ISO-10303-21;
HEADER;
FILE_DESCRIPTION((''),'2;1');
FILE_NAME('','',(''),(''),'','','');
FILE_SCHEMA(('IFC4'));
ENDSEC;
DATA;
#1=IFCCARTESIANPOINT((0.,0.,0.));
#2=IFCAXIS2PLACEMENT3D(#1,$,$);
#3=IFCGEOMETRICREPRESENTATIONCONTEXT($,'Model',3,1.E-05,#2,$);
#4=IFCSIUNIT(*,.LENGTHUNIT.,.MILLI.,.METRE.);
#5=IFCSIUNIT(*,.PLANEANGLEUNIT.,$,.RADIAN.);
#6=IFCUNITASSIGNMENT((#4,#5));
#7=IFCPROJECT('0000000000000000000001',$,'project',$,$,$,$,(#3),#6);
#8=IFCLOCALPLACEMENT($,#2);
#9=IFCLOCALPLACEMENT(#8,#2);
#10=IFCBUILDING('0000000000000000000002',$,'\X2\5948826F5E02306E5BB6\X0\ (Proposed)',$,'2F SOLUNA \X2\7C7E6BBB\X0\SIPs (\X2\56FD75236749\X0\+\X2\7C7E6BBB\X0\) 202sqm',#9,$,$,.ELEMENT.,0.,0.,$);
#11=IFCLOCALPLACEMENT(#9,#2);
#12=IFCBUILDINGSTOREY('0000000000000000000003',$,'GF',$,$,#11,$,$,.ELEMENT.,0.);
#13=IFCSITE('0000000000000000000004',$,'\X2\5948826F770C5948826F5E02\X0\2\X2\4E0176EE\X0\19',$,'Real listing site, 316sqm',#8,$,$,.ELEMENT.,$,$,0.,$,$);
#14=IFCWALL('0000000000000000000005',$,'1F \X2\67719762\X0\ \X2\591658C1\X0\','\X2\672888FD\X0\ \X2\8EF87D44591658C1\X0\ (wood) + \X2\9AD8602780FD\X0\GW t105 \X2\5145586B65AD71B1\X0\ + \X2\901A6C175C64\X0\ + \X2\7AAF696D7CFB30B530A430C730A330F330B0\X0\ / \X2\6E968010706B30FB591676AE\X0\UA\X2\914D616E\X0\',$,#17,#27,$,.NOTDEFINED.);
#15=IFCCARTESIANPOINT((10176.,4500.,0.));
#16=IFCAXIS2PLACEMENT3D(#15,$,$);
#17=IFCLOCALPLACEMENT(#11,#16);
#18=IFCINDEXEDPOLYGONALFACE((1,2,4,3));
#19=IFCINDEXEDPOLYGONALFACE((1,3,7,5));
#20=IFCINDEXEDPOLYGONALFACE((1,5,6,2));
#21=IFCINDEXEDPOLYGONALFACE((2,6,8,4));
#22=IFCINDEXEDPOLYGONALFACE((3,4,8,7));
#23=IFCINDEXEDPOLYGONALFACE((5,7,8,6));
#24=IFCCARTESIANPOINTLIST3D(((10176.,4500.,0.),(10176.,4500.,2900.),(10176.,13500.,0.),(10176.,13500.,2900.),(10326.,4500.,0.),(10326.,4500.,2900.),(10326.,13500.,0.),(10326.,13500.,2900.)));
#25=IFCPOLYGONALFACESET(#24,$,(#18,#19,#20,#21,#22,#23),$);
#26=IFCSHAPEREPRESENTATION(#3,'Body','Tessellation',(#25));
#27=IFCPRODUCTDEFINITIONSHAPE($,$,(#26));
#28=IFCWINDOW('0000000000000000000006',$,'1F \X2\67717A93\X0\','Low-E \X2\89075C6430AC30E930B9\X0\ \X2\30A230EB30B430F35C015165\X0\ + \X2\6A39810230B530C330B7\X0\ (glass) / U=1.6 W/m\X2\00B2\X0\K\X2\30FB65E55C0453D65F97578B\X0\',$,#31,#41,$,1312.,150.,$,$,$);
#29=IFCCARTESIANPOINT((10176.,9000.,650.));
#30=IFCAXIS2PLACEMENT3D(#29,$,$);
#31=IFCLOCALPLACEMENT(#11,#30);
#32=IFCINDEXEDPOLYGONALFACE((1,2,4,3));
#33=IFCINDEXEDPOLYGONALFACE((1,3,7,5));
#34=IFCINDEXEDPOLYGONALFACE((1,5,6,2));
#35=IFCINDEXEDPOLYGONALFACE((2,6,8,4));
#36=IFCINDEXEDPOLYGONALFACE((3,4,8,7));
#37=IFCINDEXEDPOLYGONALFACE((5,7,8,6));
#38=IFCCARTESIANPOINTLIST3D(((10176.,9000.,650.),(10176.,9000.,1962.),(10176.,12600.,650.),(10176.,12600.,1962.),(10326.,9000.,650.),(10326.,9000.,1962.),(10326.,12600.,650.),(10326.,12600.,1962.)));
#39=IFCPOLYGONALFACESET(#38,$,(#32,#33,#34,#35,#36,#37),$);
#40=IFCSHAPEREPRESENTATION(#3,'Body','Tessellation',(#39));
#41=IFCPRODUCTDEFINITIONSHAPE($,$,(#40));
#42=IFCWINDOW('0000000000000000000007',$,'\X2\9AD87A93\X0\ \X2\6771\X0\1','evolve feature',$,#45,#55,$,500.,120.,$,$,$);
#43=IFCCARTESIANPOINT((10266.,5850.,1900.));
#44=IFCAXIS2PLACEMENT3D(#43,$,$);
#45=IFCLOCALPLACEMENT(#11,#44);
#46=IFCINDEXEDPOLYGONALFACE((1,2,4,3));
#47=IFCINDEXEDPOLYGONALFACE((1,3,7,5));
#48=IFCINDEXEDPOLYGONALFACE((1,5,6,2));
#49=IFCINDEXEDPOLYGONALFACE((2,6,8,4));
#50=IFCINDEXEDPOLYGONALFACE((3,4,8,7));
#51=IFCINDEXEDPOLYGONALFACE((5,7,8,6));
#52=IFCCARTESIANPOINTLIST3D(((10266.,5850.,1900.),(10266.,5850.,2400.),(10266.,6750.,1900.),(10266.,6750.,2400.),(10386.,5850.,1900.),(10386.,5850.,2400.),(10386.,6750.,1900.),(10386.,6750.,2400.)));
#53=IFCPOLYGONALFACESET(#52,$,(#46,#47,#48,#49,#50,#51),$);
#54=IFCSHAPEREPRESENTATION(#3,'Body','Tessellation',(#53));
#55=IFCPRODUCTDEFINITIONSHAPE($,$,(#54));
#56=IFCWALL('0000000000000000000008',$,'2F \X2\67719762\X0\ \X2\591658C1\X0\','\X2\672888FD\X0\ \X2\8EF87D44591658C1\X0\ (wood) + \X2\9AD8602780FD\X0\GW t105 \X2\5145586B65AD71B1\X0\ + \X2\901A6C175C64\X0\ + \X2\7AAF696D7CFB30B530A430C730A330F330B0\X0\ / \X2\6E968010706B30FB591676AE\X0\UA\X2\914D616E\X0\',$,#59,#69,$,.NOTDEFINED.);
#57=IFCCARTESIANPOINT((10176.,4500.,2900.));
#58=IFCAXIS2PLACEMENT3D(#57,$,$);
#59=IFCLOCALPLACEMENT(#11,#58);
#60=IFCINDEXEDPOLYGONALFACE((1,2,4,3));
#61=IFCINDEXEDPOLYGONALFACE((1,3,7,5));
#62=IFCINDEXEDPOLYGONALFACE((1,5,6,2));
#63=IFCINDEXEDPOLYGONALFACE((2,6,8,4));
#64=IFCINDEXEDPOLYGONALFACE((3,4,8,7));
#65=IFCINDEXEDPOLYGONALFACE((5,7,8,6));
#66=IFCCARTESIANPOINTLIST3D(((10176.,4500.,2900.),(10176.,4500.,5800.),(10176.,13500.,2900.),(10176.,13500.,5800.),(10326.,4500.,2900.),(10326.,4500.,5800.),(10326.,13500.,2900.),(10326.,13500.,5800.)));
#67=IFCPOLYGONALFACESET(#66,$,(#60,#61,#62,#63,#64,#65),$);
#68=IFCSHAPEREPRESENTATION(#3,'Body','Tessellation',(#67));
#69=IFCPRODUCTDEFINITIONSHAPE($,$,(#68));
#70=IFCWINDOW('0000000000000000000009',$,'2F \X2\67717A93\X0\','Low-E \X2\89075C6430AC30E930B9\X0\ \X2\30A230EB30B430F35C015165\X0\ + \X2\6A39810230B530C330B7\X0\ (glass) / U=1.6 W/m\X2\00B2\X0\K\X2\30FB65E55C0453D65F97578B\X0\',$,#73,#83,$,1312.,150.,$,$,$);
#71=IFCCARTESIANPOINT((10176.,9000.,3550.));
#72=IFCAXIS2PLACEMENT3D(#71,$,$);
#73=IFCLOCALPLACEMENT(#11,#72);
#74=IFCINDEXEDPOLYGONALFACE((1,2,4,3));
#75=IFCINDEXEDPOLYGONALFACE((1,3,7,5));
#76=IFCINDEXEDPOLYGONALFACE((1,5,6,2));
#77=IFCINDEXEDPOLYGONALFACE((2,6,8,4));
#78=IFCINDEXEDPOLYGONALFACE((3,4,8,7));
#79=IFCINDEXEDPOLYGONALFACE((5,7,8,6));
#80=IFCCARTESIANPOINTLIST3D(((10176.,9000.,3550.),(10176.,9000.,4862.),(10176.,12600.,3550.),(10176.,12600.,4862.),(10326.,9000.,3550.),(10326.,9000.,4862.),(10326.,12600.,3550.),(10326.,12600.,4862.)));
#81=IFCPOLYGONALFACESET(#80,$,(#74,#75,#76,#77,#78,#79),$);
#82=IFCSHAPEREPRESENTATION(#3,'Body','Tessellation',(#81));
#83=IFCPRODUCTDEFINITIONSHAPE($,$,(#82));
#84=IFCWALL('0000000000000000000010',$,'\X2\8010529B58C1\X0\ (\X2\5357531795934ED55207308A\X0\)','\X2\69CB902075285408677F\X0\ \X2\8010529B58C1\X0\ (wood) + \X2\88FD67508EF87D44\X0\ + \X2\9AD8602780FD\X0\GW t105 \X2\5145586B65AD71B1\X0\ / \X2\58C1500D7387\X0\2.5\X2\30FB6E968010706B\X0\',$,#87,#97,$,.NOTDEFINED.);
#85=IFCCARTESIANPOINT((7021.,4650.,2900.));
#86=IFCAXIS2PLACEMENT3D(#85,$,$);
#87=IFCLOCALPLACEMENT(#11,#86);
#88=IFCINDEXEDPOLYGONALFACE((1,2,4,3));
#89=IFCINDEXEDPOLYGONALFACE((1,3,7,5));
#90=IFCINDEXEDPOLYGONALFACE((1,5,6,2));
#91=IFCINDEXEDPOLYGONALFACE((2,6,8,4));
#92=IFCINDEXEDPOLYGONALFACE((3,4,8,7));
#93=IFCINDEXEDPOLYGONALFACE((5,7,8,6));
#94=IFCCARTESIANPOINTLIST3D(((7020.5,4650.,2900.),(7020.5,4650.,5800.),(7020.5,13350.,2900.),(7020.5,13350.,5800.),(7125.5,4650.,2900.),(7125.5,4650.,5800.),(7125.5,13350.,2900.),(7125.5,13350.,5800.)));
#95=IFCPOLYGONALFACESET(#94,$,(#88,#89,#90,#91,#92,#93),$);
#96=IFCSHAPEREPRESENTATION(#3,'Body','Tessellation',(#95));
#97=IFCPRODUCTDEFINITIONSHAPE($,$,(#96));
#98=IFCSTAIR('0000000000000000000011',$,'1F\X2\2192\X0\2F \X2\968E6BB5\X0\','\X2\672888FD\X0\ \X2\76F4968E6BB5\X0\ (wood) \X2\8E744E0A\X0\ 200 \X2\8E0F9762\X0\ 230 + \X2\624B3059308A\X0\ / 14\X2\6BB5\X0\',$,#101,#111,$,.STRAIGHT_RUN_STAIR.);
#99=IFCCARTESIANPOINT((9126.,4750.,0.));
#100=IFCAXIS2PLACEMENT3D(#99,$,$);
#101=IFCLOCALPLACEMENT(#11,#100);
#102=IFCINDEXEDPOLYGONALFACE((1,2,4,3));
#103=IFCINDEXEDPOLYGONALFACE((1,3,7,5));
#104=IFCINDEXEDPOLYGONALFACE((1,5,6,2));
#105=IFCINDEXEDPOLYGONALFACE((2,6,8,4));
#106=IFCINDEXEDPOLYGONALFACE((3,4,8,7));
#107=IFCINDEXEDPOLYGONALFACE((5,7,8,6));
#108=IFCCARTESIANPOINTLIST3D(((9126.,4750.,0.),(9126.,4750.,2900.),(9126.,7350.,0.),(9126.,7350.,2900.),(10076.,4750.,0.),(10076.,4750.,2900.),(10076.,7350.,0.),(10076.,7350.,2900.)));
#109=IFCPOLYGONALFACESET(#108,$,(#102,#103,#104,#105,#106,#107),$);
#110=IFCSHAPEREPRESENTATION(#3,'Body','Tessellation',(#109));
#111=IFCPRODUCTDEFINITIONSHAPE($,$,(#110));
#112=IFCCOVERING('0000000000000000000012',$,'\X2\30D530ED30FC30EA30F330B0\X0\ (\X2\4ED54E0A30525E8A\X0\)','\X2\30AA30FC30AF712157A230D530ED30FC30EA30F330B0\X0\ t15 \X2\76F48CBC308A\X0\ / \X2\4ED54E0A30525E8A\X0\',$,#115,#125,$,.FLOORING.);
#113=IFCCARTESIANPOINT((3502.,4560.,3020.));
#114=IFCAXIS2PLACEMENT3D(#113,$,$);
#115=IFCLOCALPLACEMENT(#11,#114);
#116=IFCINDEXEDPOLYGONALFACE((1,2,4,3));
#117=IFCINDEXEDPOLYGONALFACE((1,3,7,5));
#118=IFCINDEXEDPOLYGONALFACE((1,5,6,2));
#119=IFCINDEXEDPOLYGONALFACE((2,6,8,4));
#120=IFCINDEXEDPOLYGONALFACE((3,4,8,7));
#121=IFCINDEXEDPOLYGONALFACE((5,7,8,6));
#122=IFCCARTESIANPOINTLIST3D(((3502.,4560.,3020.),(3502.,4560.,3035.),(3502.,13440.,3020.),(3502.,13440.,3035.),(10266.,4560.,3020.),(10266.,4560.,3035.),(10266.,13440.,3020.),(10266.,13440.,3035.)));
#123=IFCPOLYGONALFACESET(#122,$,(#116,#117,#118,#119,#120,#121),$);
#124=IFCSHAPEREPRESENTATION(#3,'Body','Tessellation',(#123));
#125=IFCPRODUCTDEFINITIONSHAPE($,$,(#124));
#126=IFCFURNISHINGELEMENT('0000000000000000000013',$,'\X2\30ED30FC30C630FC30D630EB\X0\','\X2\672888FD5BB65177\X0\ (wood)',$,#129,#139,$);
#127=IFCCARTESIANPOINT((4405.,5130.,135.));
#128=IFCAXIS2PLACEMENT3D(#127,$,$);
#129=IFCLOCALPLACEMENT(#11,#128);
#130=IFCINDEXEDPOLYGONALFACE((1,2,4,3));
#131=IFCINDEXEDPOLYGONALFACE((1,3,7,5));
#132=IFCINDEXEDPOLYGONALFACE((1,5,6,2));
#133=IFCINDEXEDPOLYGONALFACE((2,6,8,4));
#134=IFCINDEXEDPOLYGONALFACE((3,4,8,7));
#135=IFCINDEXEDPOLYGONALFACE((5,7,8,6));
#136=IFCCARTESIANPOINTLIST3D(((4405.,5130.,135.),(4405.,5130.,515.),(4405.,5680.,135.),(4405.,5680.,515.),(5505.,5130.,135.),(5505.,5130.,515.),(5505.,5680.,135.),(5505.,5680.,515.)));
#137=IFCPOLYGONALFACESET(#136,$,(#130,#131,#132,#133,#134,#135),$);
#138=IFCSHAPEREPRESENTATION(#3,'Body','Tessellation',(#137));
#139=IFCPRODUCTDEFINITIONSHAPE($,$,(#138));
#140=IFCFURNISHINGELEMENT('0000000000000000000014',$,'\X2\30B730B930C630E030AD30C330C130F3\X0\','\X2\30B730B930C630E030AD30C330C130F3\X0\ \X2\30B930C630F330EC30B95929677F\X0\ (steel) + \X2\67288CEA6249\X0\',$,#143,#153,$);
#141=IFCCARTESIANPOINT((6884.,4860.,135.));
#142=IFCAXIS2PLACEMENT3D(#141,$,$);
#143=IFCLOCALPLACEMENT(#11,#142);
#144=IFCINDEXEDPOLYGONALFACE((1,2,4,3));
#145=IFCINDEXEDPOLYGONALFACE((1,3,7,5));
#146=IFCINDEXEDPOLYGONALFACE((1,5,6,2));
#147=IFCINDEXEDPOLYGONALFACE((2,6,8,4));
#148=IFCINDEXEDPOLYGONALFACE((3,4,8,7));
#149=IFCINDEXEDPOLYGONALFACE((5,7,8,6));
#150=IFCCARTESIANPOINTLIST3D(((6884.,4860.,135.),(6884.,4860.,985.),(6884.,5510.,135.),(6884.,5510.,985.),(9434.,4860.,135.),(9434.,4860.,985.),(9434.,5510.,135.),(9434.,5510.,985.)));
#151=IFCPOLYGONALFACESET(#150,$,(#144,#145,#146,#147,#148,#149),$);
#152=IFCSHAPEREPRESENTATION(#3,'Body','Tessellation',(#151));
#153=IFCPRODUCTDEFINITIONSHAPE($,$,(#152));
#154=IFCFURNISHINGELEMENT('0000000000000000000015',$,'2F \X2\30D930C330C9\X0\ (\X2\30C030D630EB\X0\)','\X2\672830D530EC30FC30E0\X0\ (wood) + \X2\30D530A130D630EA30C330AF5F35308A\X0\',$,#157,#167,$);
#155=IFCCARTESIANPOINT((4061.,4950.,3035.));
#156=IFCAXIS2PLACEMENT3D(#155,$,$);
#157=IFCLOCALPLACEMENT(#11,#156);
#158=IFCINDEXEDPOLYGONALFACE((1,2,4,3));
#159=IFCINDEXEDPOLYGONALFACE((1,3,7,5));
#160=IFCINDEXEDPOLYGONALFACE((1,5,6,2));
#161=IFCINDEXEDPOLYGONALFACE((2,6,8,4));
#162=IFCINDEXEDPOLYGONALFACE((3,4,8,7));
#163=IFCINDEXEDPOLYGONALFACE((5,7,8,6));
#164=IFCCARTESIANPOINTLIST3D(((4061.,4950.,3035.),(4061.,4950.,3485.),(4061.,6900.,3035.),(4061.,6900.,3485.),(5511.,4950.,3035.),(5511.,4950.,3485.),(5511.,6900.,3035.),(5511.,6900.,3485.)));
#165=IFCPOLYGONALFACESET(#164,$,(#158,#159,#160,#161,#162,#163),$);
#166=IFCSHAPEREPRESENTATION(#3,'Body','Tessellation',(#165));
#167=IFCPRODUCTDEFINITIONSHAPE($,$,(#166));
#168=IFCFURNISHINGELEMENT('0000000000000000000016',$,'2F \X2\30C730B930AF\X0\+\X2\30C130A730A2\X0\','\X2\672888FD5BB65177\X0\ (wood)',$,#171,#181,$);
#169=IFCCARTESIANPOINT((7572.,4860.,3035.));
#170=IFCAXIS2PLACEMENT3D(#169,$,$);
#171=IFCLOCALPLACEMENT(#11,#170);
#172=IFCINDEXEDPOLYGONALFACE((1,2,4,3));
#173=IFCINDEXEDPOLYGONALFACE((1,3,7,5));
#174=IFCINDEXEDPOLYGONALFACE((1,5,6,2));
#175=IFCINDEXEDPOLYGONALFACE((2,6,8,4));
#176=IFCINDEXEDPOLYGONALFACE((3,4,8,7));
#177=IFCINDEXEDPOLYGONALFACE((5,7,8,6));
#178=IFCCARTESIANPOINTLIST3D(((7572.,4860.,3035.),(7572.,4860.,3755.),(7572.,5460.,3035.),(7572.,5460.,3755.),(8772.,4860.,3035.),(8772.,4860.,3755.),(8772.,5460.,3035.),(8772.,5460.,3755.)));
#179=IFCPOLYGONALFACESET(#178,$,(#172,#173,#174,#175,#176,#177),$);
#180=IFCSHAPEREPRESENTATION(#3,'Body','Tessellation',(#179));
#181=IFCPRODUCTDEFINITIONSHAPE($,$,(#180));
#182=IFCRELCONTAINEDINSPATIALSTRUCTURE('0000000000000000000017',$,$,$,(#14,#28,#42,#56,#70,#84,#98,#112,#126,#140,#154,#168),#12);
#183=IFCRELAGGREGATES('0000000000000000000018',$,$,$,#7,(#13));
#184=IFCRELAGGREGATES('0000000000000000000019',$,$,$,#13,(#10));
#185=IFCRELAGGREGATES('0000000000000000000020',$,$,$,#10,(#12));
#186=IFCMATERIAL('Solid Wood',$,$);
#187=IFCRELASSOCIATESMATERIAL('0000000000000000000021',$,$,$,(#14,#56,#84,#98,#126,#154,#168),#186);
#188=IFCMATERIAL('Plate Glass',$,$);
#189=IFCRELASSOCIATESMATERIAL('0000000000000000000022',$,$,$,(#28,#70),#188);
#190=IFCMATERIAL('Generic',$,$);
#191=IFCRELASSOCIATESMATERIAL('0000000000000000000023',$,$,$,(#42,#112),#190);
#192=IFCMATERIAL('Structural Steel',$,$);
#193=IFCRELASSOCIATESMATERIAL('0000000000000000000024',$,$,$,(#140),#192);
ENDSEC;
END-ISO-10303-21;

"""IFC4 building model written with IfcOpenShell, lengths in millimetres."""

from ifc_helpers import new_model, si_unit, frame, frame_2d, origin, place, context, project, spatial, rectangle, extrude, material, element, fill, save


model = new_model("IFC4")

# Units and contexts
model_context = context("Model", 3, precision=1e-05, world=origin())
ifc_project = project(units=[si_unit("LENGTHUNIT", "METRE", prefix="MILLI"), si_unit("PLANEANGLEUNIT", "RADIAN")], contexts=[model_context])

# Site, building, storey
site_placement = place(None, origin())
site = spatial("IfcSite", under=ifc_project, at=site_placement, Name="奈良県奈良市2丁目19", ObjectType="Real listing site, 316sqm", CompositionType="ELEMENT", RefElevation=0.0)
building_placement = place(site_placement, origin())
building = spatial("IfcBuilding", under=site, at=building_placement, Name="奈良市の家 (Proposed)", ObjectType="2F SOLUNA 籾殻SIPs (国産杉+籾殻) 202sqm", CompositionType="ELEMENT", ElevationOfRefHeight=0.0, ElevationOfTerrain=0.0)
storey_placement = place(building_placement, origin())
storey = spatial("IfcBuildingStorey", under=building, at=storey_placement, Name="GF", CompositionType="ELEMENT", Elevation=0.0)

# Shared definitions
ifc_material_1 = material(Name="Solid Wood")

# Wall, openings, windows
wall_1_placement = place(storey_placement, frame((10176.0, 4500.0, 0.0)))
wall_1 = element("IfcWall", 1, at=wall_1_placement, inside=storey, material=ifc_material_1, Name="1F 東面 外壁", Description="木製 軸組外壁 (wood) + 高性能GW t105 充填断熱 + 通気層 + 窯業系サイディング / 準耐火・外皮UA配慮", PredefinedType="NOTDEFINED", context=model_context, shape_type="SweptSolid", body=[
    extrude(rectangle(XDim=150.0, YDim=9000.0, at=frame_2d((75.0, 4500.0))), frame((10176.0, 4500.0, 0.0)), (0.0, 0.0, 1.0), 2900.0),
])
opening_1_placement = place(storey_placement, frame((10176.0, 9000.0, 650.0)))
opening_1 = element("IfcOpeningElement", 2, at=opening_1_placement, cuts=wall_1, PredefinedType="NOTDEFINED", context=model_context, shape_type="SweptSolid", body=[
    extrude(rectangle(XDim=150.0, YDim=3600.0, at=frame_2d((75.0, 1800.0))), frame((10176.0, 9000.0, 650.0)), (0.0, 0.0, 1.0), 1312.0),
])
opening_2_placement = place(storey_placement, frame((10266.0, 5850.0, 1900.0)))
opening_2 = element("IfcOpeningElement", 3, at=opening_2_placement, cuts=wall_1, PredefinedType="NOTDEFINED", context=model_context, shape_type="SweptSolid", body=[
    extrude(rectangle(XDim=120.0, YDim=900.0, at=frame_2d((60.0, 450.0))), frame((10266.0, 5850.0, 1900.0)), (0.0, 0.0, 1.0), 500.0),
])
ifc_material_2 = material(Name="Plate Glass")
window_1_placement = place(storey_placement, frame((10176.0, 9000.0, 650.0)))
window_1 = element("IfcWindow", 4, at=window_1_placement, inside=storey, material=ifc_material_2, Name="1F 東窓", Description="Low-E 複層ガラス アルゴン封入 + 樹脂サッシ (glass) / U=1.6 W/m²K・日射取得型", OverallHeight=1312.0, OverallWidth=150.0, context=model_context, shape_type="SweptSolid", body=[
    extrude(rectangle(XDim=150.0, YDim=3600.0, at=frame_2d((75.0, 1800.0))), frame((10176.0, 9000.0, 650.0)), (0.0, 0.0, 1.0), 1312.0),
])
fill(opening_1, window_1)
ifc_material_3 = material(Name="Generic")
window_2_placement = place(storey_placement, frame((10266.0, 5850.0, 1900.0)))
window_2 = element("IfcWindow", 5, at=window_2_placement, inside=storey, material=ifc_material_3, Name="高窓 東1", Description="evolve feature", OverallHeight=500.0, OverallWidth=120.0, context=model_context, shape_type="SweptSolid", body=[
    extrude(rectangle(XDim=120.0, YDim=900.0, at=frame_2d((60.0, 450.0))), frame((10266.0, 5850.0, 1900.0)), (0.0, 0.0, 1.0), 500.0),
])
fill(opening_2, window_2)

# Wall, opening, window
wall_2_placement = place(storey_placement, frame((10176.0, 4500.0, 2900.0)))
wall_2 = element("IfcWall", 6, at=wall_2_placement, inside=storey, material=ifc_material_1, Name="2F 東面 外壁", Description="木製 軸組外壁 (wood) + 高性能GW t105 充填断熱 + 通気層 + 窯業系サイディング / 準耐火・外皮UA配慮", PredefinedType="NOTDEFINED", context=model_context, shape_type="SweptSolid", body=[
    extrude(rectangle(XDim=150.0, YDim=9000.0, at=frame_2d((75.0, 4500.0))), frame((10176.0, 4500.0, 2900.0)), (0.0, 0.0, 1.0), 2900.0),
])
opening_3_placement = place(storey_placement, frame((10176.0, 9000.0, 3550.0)))
opening_3 = element("IfcOpeningElement", 7, at=opening_3_placement, cuts=wall_2, PredefinedType="NOTDEFINED", context=model_context, shape_type="SweptSolid", body=[
    extrude(rectangle(XDim=150.0, YDim=3600.0, at=frame_2d((75.0, 1800.0))), frame((10176.0, 9000.0, 3550.0)), (0.0, 0.0, 1.0), 1312.0),
])
window_3_placement = place(storey_placement, frame((10176.0, 9000.0, 3550.0)))
window_3 = element("IfcWindow", 8, at=window_3_placement, inside=storey, material=ifc_material_2, Name="2F 東窓", Description="Low-E 複層ガラス アルゴン封入 + 樹脂サッシ (glass) / U=1.6 W/m²K・日射取得型", OverallHeight=1312.0, OverallWidth=150.0, context=model_context, shape_type="SweptSolid", body=[
    extrude(rectangle(XDim=150.0, YDim=3600.0, at=frame_2d((75.0, 1800.0))), frame((10176.0, 9000.0, 3550.0)), (0.0, 0.0, 1.0), 1312.0),
])
fill(opening_3, window_3)

# Wall
wall_3_placement = place(storey_placement, frame((7021.0, 4650.0, 2900.0)))
element("IfcWall", 9, at=wall_3_placement, inside=storey, material=ifc_material_1, Name="耐力壁 (南北間仕切り)", Description="構造用合板 耐力壁 (wood) + 製材軸組 + 高性能GW t105 充填断熱 / 壁倍率2.5・準耐火", PredefinedType="NOTDEFINED", context=model_context, shape_type="SweptSolid", body=[
    extrude(rectangle(XDim=105.0, YDim=8700.0, at=frame_2d((52.0, 4350.0))), frame((7021.0, 4650.0, 2900.0)), (0.0, 0.0, 1.0), 2900.0),
])

# Stair
stair_placement = place(storey_placement, frame((9126.0, 4750.0, 0.0)))
element("IfcStair", 10, at=stair_placement, inside=storey, material=ifc_material_1, Name="1F→2F 階段", Description="木製 直階段 (wood) 蹴上 200 踏面 230 + 手すり / 14段", PredefinedType="STRAIGHT_RUN_STAIR", context=model_context, shape_type="SweptSolid", body=[
    extrude(rectangle(XDim=950.0, YDim=2600.0, at=frame_2d((475.0, 1300.0))), frame((9126.0, 4750.0, 0.0)), (0.0, 0.0, 1.0), 2900.0),
])

# Covering
covering_placement = place(storey_placement, frame((3502.0, 4560.0, 3020.0)))
element("IfcCovering", 11, at=covering_placement, inside=storey, material=ifc_material_3, Name="フローリング (仕上げ床)", Description="オーク無垢フローリング t15 直貼り / 仕上げ床", PredefinedType="FLOORING", context=model_context, shape_type="SweptSolid", body=[
    extrude(rectangle(XDim=6764.0, YDim=8880.0, at=frame_2d((3382.0, 4440.0))), frame((3502.0, 4560.0, 3020.0)), (0.0, 0.0, 1.0), 15.0),
])

# Furnishing elements
furnishing_1_placement = place(storey_placement, frame((4405.0, 5130.0, 135.0)))
element("IfcFurnishingElement", 12, at=furnishing_1_placement, inside=storey, material=ifc_material_1, Name="ローテーブル", Description="木製家具 (wood)", context=model_context, shape_type="SweptSolid", body=[
    extrude(rectangle(XDim=1100.0, YDim=550.0, at=frame_2d((550.0, 275.0))), frame((4405.0, 5130.0, 135.0)), (0.0, 0.0, 1.0), 380.0),
])
ifc_material_4 = material(Name="Structural Steel")
furnishing_2_placement = place(storey_placement, frame((6884.0, 4860.0, 135.0)))
element("IfcFurnishingElement", 13, at=furnishing_2_placement, inside=storey, material=ifc_material_4, Name="システムキッチン", Description="システムキッチン ステンレス天板 (steel) + 木質扉", context=model_context, shape_type="SweptSolid", body=[
    extrude(rectangle(XDim=2550.0, YDim=650.0, at=frame_2d((1275.0, 325.0))), frame((6884.0, 4860.0, 135.0)), (0.0, 0.0, 1.0), 850.0),
])
furnishing_3_placement = place(storey_placement, frame((4061.0, 4950.0, 3035.0)))
element("IfcFurnishingElement", 14, at=furnishing_3_placement, inside=storey, material=ifc_material_1, Name="2F ベッド (ダブル)", Description="木フレーム (wood) + ファブリック張り", context=model_context, shape_type="SweptSolid", body=[
    extrude(rectangle(XDim=1450.0, YDim=1950.0, at=frame_2d((725.0, 975.0))), frame((4061.0, 4950.0, 3035.0)), (0.0, 0.0, 1.0), 450.0),
])
furnishing_4_placement = place(storey_placement, frame((7572.0, 4860.0, 3035.0)))
element("IfcFurnishingElement", 15, at=furnishing_4_placement, inside=storey, material=ifc_material_1, Name="2F デスク+チェア", Description="木製家具 (wood)", context=model_context, shape_type="SweptSolid", body=[
    extrude(rectangle(XDim=1200.0, YDim=600.0, at=frame_2d((600.0, 300.0))), frame((7572.0, 4860.0, 3035.0)), (0.0, 0.0, 1.0), 720.0),
])

save(model, "model.ifc")
